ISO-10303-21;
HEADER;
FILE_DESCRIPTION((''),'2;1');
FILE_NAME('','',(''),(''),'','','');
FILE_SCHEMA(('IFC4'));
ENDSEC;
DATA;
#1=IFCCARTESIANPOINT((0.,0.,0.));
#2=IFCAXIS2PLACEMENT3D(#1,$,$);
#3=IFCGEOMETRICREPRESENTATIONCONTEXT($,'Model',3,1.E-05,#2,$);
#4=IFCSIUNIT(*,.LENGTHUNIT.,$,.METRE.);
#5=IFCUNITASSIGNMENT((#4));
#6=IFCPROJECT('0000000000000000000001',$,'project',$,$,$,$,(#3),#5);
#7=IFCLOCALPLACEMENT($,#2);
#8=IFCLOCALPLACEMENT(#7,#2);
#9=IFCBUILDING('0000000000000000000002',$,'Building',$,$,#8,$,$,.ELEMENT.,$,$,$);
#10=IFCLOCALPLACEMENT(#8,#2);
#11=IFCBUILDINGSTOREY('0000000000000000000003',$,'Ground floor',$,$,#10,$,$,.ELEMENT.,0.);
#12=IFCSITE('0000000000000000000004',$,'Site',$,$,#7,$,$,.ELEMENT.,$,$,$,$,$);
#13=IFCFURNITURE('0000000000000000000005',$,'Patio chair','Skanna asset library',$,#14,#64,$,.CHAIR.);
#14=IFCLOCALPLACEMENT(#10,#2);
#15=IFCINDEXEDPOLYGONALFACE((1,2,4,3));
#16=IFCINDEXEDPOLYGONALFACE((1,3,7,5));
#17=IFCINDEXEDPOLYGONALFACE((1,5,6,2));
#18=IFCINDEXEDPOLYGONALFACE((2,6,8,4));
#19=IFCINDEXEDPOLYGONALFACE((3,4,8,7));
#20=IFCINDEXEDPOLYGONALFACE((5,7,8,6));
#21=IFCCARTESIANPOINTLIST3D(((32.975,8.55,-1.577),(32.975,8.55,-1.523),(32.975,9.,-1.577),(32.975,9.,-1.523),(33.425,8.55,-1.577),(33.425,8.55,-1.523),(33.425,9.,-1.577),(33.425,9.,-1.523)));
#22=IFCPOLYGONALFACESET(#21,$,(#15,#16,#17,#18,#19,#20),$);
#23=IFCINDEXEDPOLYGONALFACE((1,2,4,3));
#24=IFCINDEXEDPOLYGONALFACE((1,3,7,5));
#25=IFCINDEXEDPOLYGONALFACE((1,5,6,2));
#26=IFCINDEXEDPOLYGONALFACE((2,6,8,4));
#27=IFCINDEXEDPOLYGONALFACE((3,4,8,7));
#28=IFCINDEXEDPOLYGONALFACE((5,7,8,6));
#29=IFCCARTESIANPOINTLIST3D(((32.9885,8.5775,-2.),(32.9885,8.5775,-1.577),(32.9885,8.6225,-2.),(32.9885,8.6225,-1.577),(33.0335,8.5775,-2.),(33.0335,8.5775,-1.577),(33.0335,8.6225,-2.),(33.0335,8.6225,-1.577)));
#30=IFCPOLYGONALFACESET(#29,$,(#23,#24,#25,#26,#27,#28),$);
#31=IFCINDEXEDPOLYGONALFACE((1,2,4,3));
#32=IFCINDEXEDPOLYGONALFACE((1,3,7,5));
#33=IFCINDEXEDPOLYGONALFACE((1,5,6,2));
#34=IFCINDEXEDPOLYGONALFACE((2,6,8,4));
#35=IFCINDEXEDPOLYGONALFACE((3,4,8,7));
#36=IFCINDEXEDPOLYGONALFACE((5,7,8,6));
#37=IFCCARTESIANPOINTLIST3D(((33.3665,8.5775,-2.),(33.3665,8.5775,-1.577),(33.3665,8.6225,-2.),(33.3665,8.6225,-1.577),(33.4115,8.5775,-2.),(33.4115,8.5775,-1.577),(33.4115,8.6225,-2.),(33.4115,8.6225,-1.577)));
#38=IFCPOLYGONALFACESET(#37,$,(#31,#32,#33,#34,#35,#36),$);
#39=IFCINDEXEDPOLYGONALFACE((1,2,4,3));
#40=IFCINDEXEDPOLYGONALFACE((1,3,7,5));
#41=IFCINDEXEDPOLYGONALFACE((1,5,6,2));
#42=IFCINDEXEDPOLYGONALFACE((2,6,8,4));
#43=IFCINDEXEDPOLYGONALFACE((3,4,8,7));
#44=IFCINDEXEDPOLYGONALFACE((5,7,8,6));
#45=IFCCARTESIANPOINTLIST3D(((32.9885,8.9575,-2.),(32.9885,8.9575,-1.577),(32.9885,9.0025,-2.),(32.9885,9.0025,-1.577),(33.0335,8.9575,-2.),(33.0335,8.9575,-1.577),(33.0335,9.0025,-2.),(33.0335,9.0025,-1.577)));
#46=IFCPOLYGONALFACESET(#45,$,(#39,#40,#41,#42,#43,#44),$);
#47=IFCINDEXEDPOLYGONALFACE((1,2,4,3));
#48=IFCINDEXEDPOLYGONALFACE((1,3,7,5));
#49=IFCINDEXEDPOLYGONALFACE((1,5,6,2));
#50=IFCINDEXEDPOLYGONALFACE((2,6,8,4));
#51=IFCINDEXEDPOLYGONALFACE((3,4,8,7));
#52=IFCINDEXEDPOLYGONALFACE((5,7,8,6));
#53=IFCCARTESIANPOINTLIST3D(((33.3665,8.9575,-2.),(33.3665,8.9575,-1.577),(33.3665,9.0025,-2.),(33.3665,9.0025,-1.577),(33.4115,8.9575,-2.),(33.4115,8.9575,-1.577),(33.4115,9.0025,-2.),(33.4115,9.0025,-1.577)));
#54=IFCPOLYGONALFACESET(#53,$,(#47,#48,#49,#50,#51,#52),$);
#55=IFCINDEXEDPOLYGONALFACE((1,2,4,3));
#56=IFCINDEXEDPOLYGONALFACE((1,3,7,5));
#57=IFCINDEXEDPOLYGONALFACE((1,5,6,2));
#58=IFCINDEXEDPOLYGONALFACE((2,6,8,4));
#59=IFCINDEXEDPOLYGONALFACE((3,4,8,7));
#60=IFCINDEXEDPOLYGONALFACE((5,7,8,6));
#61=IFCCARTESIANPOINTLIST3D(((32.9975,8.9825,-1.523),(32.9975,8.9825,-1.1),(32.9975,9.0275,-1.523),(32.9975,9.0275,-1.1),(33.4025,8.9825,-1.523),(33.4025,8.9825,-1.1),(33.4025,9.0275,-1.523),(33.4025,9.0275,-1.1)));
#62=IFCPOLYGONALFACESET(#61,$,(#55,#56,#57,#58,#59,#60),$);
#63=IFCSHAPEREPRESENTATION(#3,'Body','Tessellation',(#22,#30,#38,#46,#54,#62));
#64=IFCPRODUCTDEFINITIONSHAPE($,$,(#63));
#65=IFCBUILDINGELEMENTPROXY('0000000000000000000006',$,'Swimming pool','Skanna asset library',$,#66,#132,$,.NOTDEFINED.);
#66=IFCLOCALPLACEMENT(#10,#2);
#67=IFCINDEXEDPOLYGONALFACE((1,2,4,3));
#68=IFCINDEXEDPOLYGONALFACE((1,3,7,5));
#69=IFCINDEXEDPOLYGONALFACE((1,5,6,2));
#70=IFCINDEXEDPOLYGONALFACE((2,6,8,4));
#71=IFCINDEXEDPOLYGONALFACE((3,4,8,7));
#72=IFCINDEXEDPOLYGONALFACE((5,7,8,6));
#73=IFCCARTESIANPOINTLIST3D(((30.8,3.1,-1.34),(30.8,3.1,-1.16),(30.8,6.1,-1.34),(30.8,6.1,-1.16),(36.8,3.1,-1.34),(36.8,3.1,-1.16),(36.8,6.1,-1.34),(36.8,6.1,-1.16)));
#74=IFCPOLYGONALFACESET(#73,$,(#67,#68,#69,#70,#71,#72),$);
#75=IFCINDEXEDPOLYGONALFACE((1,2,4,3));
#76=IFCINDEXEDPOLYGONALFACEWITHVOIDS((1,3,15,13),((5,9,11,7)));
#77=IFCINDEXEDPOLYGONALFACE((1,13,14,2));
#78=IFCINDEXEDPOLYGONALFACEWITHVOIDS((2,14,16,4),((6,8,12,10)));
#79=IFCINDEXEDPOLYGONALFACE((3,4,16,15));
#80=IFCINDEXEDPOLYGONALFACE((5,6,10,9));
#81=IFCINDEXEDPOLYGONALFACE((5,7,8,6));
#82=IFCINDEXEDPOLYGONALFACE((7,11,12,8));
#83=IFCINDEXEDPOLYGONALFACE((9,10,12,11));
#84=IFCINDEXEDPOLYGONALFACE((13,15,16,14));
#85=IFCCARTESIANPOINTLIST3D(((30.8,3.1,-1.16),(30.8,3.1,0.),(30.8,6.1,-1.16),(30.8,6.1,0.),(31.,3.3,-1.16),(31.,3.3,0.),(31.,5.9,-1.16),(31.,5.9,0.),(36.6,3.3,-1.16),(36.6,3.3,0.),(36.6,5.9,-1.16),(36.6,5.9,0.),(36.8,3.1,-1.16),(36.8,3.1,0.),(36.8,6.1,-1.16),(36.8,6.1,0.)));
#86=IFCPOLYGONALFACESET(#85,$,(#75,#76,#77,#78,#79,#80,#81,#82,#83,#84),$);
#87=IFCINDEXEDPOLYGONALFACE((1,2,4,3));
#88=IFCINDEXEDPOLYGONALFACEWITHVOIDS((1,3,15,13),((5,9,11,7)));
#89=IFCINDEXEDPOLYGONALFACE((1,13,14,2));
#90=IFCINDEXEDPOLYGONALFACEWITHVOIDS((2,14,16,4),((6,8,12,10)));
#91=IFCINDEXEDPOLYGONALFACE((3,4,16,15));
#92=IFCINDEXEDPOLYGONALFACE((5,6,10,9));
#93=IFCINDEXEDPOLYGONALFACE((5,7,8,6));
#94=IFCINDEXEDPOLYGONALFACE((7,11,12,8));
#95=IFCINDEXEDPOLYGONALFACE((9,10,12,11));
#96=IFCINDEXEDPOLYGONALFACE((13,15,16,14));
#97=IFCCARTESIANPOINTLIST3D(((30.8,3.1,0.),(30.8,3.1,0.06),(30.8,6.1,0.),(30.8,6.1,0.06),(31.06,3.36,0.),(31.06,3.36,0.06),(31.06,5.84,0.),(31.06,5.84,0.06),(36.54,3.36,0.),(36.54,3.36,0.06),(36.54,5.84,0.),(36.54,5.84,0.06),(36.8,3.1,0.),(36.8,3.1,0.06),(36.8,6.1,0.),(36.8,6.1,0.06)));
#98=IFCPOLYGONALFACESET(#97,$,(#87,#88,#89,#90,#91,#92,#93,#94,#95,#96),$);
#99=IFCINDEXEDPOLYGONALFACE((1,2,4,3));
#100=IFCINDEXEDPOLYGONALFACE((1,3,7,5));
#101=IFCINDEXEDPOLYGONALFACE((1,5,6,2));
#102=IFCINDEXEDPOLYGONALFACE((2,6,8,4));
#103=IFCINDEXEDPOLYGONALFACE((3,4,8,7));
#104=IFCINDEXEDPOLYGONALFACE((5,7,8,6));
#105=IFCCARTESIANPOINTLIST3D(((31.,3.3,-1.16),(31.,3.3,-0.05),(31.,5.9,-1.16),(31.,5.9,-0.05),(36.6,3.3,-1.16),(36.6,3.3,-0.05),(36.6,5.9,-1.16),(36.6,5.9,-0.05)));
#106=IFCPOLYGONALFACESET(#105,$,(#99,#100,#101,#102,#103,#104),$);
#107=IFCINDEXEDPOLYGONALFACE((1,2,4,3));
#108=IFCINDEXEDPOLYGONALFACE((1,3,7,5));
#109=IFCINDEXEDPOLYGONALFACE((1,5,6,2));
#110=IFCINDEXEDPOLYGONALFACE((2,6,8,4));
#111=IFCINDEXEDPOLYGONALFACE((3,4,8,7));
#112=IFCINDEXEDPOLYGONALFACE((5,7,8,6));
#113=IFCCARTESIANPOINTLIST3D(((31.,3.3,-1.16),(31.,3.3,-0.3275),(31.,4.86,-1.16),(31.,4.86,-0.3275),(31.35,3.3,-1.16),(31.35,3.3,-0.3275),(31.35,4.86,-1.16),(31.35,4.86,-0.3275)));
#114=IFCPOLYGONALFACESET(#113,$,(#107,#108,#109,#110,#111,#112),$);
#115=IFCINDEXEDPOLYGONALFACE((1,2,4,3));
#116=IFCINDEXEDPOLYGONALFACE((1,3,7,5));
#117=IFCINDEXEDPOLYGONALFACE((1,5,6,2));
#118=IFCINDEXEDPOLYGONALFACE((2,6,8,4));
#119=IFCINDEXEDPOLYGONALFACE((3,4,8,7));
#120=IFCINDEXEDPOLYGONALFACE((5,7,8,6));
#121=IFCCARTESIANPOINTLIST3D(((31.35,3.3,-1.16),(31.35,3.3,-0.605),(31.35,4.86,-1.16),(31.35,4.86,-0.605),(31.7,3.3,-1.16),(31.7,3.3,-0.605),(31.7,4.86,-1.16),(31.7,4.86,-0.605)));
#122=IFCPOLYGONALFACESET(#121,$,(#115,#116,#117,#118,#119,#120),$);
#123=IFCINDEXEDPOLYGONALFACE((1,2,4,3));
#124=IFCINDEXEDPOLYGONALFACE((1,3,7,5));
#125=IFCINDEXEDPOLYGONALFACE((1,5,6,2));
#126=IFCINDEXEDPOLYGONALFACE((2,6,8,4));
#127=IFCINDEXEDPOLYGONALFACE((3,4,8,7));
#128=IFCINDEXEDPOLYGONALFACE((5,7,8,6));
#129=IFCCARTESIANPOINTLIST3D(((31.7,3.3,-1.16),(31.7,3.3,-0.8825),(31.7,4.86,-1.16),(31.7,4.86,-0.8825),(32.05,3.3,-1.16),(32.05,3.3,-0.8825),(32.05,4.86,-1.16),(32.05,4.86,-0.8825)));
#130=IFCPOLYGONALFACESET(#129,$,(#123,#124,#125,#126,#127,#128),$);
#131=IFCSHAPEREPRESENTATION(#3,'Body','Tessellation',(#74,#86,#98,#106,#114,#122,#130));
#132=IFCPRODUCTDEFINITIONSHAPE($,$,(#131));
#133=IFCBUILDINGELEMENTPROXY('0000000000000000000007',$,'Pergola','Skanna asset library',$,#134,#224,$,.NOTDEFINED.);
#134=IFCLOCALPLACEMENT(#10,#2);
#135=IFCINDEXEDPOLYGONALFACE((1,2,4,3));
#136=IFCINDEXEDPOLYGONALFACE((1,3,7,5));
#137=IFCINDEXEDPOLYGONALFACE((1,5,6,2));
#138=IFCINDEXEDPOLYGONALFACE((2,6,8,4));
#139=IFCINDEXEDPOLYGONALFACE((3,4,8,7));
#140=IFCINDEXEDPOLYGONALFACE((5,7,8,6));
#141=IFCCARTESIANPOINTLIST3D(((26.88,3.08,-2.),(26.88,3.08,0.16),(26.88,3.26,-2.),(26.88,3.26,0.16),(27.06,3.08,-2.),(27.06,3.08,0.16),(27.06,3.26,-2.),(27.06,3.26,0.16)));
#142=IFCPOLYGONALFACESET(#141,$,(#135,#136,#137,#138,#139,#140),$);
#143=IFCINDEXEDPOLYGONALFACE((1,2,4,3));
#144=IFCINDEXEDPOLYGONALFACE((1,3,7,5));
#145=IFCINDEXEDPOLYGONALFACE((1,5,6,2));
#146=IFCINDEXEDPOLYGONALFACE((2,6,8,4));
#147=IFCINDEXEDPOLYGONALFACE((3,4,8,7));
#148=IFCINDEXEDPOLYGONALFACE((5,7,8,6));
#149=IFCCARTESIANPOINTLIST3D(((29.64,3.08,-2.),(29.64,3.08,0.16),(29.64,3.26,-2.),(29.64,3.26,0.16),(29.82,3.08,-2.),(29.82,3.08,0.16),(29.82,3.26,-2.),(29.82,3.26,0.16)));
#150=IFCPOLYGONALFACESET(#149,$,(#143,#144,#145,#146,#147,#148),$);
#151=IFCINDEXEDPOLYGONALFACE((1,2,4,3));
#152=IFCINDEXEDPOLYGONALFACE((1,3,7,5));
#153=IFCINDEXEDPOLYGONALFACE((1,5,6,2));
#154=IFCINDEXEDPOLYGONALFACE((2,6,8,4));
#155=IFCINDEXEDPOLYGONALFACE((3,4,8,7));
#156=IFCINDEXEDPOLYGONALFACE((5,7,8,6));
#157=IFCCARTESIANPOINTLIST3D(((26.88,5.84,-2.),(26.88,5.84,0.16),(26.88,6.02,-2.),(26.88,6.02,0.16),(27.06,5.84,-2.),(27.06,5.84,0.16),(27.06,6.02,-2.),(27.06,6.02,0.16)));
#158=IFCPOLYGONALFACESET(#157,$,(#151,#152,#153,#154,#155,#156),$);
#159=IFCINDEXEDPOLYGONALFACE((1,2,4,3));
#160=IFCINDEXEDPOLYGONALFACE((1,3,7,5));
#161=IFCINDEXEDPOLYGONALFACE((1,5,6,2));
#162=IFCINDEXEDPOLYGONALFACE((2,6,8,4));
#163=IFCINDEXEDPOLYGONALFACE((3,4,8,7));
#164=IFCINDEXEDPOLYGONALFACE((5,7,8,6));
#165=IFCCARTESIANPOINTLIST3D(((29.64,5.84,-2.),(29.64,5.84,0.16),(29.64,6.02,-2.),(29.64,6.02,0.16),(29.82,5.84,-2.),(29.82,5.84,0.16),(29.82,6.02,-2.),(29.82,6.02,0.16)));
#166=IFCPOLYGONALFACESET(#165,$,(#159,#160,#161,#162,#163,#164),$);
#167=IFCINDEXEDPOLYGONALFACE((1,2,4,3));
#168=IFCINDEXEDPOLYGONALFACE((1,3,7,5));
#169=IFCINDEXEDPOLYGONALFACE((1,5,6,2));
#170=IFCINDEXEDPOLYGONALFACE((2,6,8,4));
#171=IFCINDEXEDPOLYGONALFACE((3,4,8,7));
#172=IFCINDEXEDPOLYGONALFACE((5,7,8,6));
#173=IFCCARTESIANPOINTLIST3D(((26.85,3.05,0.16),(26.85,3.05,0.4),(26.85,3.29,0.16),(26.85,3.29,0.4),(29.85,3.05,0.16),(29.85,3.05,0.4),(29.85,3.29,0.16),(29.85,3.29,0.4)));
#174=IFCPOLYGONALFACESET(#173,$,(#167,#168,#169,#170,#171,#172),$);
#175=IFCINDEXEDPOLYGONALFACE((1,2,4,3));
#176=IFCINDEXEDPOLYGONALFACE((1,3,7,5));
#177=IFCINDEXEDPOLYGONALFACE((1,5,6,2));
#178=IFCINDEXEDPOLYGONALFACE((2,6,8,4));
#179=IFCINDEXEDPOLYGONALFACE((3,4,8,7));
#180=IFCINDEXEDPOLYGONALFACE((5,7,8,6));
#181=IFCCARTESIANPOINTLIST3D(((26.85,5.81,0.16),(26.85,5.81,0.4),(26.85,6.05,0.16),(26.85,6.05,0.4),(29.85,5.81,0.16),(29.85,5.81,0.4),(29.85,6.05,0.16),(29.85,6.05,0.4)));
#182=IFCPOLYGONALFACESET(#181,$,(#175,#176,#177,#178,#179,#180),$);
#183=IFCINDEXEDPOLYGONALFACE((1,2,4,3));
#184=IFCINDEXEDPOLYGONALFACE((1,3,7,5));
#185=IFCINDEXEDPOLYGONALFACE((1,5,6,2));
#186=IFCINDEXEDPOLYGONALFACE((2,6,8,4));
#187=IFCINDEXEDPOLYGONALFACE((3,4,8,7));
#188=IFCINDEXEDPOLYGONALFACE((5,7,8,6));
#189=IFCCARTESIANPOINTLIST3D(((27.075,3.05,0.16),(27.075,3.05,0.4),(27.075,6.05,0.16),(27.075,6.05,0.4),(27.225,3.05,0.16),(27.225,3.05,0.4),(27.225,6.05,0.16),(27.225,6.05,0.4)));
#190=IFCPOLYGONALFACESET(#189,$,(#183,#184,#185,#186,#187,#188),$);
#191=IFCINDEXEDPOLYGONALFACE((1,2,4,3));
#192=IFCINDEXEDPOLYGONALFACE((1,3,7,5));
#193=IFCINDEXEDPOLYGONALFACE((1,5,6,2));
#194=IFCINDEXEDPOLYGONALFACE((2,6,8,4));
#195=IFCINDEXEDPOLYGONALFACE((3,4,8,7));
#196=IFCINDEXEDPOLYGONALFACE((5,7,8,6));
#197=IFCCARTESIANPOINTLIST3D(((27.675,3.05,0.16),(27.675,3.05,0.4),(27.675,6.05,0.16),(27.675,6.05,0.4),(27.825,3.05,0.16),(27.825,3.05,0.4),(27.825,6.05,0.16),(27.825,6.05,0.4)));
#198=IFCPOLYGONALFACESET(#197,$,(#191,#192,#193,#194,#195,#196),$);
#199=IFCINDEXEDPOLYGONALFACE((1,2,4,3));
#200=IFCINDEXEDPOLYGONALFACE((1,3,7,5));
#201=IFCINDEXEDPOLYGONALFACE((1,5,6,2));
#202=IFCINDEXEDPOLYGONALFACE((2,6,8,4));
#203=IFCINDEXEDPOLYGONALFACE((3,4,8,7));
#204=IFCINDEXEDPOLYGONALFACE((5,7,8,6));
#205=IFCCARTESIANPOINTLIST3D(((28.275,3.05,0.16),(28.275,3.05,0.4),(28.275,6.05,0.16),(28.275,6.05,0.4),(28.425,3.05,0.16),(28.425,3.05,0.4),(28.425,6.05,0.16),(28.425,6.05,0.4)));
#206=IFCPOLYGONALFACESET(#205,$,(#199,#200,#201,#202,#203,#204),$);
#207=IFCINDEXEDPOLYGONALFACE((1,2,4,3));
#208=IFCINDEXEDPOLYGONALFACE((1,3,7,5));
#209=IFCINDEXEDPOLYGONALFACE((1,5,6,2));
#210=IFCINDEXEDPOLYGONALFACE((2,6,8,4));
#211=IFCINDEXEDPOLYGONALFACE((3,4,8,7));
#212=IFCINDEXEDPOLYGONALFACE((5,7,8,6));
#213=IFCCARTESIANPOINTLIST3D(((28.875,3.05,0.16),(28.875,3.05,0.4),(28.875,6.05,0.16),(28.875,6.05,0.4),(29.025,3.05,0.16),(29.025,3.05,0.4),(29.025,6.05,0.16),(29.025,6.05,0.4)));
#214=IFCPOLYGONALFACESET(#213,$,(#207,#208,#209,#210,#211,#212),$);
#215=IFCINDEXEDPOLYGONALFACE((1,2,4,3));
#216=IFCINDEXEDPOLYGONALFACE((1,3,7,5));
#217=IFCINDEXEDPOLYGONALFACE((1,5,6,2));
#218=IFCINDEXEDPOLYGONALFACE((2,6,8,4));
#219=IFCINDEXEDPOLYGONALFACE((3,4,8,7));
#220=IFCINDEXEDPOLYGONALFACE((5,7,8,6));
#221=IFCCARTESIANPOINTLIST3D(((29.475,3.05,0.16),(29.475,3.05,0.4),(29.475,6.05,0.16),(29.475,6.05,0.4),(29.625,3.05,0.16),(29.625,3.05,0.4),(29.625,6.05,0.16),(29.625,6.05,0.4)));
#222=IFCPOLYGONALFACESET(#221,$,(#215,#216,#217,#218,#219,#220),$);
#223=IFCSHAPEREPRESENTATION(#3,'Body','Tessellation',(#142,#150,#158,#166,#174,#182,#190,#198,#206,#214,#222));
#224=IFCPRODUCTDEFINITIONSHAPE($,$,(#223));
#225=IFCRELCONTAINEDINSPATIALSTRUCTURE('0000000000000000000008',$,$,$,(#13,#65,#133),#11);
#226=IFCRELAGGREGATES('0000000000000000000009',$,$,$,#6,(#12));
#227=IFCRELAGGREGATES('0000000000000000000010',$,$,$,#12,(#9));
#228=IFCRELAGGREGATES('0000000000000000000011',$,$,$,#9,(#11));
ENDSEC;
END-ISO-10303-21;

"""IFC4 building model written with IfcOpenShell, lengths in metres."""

from ifc_helpers import new_model, si_unit, frame, frame_2d, origin, origin_2d, place, context, project, spatial, polyline, rectangle, outline, extrude, element, save


model = new_model("IFC4")

# Units and contexts
model_context = context("Model", 3, precision=1e-05, world=origin())
ifc_project = project(units=[si_unit("LENGTHUNIT", "METRE")], contexts=[model_context])

# Site, building, storey
site_placement = place(None, origin())
site = spatial("IfcSite", under=ifc_project, at=site_placement, Name="Site", CompositionType="ELEMENT")
building_placement = place(site_placement, origin())
building = spatial("IfcBuilding", under=site, at=building_placement, Name="Building", CompositionType="ELEMENT")
storey_placement = place(building_placement, origin())
storey = spatial("IfcBuildingStorey", under=building, at=storey_placement, Name="Ground floor", CompositionType="ELEMENT", Elevation=0.0)

# Furniture
for number, where, z_axis, x_axis, name in (
    (1, (33.2, 8.8, -2.0), (0.0, 0.0, 1.0), (1.0, 0.0, 0.0), "Patio chair"),
):
    element("IfcFurniture", number, at=place(storey_placement, frame(where, z_axis=z_axis, x_axis=x_axis)), inside=storey, Name=name, Description="Skanna asset library", PredefinedType="CHAIR", context=model_context, shape_type="SweptSolid", body=[
        extrude(rectangle(XDim=0.45, YDim=0.45, at=frame_2d((0.0, -0.025))), frame((0.0, 0.0, 0.423)), (0.0, 0.0, 1.0), 0.054),
        extrude(rectangle(XDim=0.045, YDim=0.045, at=frame_2d((-0.189, -0.2))), origin(), (0.0, 0.0, 1.0), 0.423),
        extrude(rectangle(XDim=0.045, YDim=0.045, at=frame_2d((0.189, -0.2))), origin(), (0.0, 0.0, 1.0), 0.423),
        extrude(rectangle(XDim=0.045, YDim=0.045, at=frame_2d((-0.189, 0.18))), origin(), (0.0, 0.0, 1.0), 0.423),
        extrude(rectangle(XDim=0.045, YDim=0.045, at=frame_2d((0.189, 0.18))), origin(), (0.0, 0.0, 1.0), 0.423),
        extrude(rectangle(XDim=0.405, YDim=0.045, at=frame_2d((0.0, 0.205))), frame((0.0, 0.0, 0.477)), (0.0, 0.0, 1.0), 0.423),
    ])

# Building element proxies
proxy_1_placement = place(storey_placement, frame((33.8, 4.6, -1.34), z_axis=(0.0, 0.0, 1.0), x_axis=(1.0, 0.0, 0.0)))
element("IfcBuildingElementProxy", 2, at=proxy_1_placement, inside=storey, Name="Swimming pool", Description="Skanna asset library", PredefinedType="NOTDEFINED", context=model_context, shape_type="SweptSolid", body=[
    extrude(rectangle(XDim=6.0, YDim=3.0, at=origin_2d()), origin(), (0.0, 0.0, 1.0), 0.18),
    extrude(outline(polyline([(-3.0, -1.5), (3.0, -1.5), (3.0, 1.5), (-3.0, 1.5), (-3.0, -1.5)]), holes=[polyline([(-2.8, -1.3), (2.8, -1.3), (2.8, 1.3), (-2.8, 1.3), (-2.8, -1.3)])]), frame((0.0, 0.0, 0.18)), (0.0, 0.0, 1.0), 1.16),
    extrude(outline(polyline([(-3.0, -1.5), (3.0, -1.5), (3.0, 1.5), (-3.0, 1.5), (-3.0, -1.5)]), holes=[polyline([(-2.74, -1.24), (2.74, -1.24), (2.74, 1.24), (-2.74, 1.24), (-2.74, -1.24)])]), frame((0.0, 0.0, 1.34)), (0.0, 0.0, 1.0), 0.06),
    extrude(rectangle(XDim=5.6, YDim=2.6, at=origin_2d()), frame((0.0, 0.0, 0.18)), (0.0, 0.0, 1.0), 1.11),
    extrude(rectangle(XDim=0.35, YDim=1.56, at=frame_2d((-2.625, -0.52))), frame((0.0, 0.0, 0.18)), (0.0, 0.0, 1.0), 0.8325),
    extrude(rectangle(XDim=0.35, YDim=1.56, at=frame_2d((-2.275, -0.52))), frame((0.0, 0.0, 0.18)), (0.0, 0.0, 1.0), 0.555),
    extrude(rectangle(XDim=0.35, YDim=1.56, at=frame_2d((-1.925, -0.52))), frame((0.0, 0.0, 0.18)), (0.0, 0.0, 1.0), 0.2775),
])
proxy_2_placement = place(storey_placement, frame((28.35, 4.55, -2.0), z_axis=(0.0, 0.0, 1.0), x_axis=(1.0, 0.0, 0.0)))
element("IfcBuildingElementProxy", 3, at=proxy_2_placement, inside=storey, Name="Pergola", Description="Skanna asset library", PredefinedType="NOTDEFINED", context=model_context, shape_type="SweptSolid", body=[
    extrude(rectangle(XDim=0.18, YDim=0.18, at=frame_2d((-1.38, -1.38))), origin(), (0.0, 0.0, 1.0), 2.16),
    extrude(rectangle(XDim=0.18, YDim=0.18, at=frame_2d((1.38, -1.38))), origin(), (0.0, 0.0, 1.0), 2.16),
    extrude(rectangle(XDim=0.18, YDim=0.18, at=frame_2d((-1.38, 1.38))), origin(), (0.0, 0.0, 1.0), 2.16),
    extrude(rectangle(XDim=0.18, YDim=0.18, at=frame_2d((1.38, 1.38))), origin(), (0.0, 0.0, 1.0), 2.16),
    extrude(rectangle(XDim=3.0, YDim=0.24, at=frame_2d((0.0, -1.38))), frame((0.0, 0.0, 2.16)), (0.0, 0.0, 1.0), 0.24),
    extrude(rectangle(XDim=3.0, YDim=0.24, at=frame_2d((0.0, 1.38))), frame((0.0, 0.0, 2.16)), (0.0, 0.0, 1.0), 0.24),
    extrude(rectangle(XDim=0.15, YDim=3.0, at=frame_2d((-1.2, 0.0))), frame((0.0, 0.0, 2.16)), (0.0, 0.0, 1.0), 0.24),
    extrude(rectangle(XDim=0.15, YDim=3.0, at=frame_2d((-0.6, 0.0))), frame((0.0, 0.0, 2.16)), (0.0, 0.0, 1.0), 0.24),
    extrude(rectangle(XDim=0.15, YDim=3.0, at=origin_2d()), frame((0.0, 0.0, 2.16)), (0.0, 0.0, 1.0), 0.24),
    extrude(rectangle(XDim=0.15, YDim=3.0, at=frame_2d((0.6, 0.0))), frame((0.0, 0.0, 2.16)), (0.0, 0.0, 1.0), 0.24),
    extrude(rectangle(XDim=0.15, YDim=3.0, at=frame_2d((1.2, 0.0))), frame((0.0, 0.0, 2.16)), (0.0, 0.0, 1.0), 0.24),
])

save(model, "model.ifc")
